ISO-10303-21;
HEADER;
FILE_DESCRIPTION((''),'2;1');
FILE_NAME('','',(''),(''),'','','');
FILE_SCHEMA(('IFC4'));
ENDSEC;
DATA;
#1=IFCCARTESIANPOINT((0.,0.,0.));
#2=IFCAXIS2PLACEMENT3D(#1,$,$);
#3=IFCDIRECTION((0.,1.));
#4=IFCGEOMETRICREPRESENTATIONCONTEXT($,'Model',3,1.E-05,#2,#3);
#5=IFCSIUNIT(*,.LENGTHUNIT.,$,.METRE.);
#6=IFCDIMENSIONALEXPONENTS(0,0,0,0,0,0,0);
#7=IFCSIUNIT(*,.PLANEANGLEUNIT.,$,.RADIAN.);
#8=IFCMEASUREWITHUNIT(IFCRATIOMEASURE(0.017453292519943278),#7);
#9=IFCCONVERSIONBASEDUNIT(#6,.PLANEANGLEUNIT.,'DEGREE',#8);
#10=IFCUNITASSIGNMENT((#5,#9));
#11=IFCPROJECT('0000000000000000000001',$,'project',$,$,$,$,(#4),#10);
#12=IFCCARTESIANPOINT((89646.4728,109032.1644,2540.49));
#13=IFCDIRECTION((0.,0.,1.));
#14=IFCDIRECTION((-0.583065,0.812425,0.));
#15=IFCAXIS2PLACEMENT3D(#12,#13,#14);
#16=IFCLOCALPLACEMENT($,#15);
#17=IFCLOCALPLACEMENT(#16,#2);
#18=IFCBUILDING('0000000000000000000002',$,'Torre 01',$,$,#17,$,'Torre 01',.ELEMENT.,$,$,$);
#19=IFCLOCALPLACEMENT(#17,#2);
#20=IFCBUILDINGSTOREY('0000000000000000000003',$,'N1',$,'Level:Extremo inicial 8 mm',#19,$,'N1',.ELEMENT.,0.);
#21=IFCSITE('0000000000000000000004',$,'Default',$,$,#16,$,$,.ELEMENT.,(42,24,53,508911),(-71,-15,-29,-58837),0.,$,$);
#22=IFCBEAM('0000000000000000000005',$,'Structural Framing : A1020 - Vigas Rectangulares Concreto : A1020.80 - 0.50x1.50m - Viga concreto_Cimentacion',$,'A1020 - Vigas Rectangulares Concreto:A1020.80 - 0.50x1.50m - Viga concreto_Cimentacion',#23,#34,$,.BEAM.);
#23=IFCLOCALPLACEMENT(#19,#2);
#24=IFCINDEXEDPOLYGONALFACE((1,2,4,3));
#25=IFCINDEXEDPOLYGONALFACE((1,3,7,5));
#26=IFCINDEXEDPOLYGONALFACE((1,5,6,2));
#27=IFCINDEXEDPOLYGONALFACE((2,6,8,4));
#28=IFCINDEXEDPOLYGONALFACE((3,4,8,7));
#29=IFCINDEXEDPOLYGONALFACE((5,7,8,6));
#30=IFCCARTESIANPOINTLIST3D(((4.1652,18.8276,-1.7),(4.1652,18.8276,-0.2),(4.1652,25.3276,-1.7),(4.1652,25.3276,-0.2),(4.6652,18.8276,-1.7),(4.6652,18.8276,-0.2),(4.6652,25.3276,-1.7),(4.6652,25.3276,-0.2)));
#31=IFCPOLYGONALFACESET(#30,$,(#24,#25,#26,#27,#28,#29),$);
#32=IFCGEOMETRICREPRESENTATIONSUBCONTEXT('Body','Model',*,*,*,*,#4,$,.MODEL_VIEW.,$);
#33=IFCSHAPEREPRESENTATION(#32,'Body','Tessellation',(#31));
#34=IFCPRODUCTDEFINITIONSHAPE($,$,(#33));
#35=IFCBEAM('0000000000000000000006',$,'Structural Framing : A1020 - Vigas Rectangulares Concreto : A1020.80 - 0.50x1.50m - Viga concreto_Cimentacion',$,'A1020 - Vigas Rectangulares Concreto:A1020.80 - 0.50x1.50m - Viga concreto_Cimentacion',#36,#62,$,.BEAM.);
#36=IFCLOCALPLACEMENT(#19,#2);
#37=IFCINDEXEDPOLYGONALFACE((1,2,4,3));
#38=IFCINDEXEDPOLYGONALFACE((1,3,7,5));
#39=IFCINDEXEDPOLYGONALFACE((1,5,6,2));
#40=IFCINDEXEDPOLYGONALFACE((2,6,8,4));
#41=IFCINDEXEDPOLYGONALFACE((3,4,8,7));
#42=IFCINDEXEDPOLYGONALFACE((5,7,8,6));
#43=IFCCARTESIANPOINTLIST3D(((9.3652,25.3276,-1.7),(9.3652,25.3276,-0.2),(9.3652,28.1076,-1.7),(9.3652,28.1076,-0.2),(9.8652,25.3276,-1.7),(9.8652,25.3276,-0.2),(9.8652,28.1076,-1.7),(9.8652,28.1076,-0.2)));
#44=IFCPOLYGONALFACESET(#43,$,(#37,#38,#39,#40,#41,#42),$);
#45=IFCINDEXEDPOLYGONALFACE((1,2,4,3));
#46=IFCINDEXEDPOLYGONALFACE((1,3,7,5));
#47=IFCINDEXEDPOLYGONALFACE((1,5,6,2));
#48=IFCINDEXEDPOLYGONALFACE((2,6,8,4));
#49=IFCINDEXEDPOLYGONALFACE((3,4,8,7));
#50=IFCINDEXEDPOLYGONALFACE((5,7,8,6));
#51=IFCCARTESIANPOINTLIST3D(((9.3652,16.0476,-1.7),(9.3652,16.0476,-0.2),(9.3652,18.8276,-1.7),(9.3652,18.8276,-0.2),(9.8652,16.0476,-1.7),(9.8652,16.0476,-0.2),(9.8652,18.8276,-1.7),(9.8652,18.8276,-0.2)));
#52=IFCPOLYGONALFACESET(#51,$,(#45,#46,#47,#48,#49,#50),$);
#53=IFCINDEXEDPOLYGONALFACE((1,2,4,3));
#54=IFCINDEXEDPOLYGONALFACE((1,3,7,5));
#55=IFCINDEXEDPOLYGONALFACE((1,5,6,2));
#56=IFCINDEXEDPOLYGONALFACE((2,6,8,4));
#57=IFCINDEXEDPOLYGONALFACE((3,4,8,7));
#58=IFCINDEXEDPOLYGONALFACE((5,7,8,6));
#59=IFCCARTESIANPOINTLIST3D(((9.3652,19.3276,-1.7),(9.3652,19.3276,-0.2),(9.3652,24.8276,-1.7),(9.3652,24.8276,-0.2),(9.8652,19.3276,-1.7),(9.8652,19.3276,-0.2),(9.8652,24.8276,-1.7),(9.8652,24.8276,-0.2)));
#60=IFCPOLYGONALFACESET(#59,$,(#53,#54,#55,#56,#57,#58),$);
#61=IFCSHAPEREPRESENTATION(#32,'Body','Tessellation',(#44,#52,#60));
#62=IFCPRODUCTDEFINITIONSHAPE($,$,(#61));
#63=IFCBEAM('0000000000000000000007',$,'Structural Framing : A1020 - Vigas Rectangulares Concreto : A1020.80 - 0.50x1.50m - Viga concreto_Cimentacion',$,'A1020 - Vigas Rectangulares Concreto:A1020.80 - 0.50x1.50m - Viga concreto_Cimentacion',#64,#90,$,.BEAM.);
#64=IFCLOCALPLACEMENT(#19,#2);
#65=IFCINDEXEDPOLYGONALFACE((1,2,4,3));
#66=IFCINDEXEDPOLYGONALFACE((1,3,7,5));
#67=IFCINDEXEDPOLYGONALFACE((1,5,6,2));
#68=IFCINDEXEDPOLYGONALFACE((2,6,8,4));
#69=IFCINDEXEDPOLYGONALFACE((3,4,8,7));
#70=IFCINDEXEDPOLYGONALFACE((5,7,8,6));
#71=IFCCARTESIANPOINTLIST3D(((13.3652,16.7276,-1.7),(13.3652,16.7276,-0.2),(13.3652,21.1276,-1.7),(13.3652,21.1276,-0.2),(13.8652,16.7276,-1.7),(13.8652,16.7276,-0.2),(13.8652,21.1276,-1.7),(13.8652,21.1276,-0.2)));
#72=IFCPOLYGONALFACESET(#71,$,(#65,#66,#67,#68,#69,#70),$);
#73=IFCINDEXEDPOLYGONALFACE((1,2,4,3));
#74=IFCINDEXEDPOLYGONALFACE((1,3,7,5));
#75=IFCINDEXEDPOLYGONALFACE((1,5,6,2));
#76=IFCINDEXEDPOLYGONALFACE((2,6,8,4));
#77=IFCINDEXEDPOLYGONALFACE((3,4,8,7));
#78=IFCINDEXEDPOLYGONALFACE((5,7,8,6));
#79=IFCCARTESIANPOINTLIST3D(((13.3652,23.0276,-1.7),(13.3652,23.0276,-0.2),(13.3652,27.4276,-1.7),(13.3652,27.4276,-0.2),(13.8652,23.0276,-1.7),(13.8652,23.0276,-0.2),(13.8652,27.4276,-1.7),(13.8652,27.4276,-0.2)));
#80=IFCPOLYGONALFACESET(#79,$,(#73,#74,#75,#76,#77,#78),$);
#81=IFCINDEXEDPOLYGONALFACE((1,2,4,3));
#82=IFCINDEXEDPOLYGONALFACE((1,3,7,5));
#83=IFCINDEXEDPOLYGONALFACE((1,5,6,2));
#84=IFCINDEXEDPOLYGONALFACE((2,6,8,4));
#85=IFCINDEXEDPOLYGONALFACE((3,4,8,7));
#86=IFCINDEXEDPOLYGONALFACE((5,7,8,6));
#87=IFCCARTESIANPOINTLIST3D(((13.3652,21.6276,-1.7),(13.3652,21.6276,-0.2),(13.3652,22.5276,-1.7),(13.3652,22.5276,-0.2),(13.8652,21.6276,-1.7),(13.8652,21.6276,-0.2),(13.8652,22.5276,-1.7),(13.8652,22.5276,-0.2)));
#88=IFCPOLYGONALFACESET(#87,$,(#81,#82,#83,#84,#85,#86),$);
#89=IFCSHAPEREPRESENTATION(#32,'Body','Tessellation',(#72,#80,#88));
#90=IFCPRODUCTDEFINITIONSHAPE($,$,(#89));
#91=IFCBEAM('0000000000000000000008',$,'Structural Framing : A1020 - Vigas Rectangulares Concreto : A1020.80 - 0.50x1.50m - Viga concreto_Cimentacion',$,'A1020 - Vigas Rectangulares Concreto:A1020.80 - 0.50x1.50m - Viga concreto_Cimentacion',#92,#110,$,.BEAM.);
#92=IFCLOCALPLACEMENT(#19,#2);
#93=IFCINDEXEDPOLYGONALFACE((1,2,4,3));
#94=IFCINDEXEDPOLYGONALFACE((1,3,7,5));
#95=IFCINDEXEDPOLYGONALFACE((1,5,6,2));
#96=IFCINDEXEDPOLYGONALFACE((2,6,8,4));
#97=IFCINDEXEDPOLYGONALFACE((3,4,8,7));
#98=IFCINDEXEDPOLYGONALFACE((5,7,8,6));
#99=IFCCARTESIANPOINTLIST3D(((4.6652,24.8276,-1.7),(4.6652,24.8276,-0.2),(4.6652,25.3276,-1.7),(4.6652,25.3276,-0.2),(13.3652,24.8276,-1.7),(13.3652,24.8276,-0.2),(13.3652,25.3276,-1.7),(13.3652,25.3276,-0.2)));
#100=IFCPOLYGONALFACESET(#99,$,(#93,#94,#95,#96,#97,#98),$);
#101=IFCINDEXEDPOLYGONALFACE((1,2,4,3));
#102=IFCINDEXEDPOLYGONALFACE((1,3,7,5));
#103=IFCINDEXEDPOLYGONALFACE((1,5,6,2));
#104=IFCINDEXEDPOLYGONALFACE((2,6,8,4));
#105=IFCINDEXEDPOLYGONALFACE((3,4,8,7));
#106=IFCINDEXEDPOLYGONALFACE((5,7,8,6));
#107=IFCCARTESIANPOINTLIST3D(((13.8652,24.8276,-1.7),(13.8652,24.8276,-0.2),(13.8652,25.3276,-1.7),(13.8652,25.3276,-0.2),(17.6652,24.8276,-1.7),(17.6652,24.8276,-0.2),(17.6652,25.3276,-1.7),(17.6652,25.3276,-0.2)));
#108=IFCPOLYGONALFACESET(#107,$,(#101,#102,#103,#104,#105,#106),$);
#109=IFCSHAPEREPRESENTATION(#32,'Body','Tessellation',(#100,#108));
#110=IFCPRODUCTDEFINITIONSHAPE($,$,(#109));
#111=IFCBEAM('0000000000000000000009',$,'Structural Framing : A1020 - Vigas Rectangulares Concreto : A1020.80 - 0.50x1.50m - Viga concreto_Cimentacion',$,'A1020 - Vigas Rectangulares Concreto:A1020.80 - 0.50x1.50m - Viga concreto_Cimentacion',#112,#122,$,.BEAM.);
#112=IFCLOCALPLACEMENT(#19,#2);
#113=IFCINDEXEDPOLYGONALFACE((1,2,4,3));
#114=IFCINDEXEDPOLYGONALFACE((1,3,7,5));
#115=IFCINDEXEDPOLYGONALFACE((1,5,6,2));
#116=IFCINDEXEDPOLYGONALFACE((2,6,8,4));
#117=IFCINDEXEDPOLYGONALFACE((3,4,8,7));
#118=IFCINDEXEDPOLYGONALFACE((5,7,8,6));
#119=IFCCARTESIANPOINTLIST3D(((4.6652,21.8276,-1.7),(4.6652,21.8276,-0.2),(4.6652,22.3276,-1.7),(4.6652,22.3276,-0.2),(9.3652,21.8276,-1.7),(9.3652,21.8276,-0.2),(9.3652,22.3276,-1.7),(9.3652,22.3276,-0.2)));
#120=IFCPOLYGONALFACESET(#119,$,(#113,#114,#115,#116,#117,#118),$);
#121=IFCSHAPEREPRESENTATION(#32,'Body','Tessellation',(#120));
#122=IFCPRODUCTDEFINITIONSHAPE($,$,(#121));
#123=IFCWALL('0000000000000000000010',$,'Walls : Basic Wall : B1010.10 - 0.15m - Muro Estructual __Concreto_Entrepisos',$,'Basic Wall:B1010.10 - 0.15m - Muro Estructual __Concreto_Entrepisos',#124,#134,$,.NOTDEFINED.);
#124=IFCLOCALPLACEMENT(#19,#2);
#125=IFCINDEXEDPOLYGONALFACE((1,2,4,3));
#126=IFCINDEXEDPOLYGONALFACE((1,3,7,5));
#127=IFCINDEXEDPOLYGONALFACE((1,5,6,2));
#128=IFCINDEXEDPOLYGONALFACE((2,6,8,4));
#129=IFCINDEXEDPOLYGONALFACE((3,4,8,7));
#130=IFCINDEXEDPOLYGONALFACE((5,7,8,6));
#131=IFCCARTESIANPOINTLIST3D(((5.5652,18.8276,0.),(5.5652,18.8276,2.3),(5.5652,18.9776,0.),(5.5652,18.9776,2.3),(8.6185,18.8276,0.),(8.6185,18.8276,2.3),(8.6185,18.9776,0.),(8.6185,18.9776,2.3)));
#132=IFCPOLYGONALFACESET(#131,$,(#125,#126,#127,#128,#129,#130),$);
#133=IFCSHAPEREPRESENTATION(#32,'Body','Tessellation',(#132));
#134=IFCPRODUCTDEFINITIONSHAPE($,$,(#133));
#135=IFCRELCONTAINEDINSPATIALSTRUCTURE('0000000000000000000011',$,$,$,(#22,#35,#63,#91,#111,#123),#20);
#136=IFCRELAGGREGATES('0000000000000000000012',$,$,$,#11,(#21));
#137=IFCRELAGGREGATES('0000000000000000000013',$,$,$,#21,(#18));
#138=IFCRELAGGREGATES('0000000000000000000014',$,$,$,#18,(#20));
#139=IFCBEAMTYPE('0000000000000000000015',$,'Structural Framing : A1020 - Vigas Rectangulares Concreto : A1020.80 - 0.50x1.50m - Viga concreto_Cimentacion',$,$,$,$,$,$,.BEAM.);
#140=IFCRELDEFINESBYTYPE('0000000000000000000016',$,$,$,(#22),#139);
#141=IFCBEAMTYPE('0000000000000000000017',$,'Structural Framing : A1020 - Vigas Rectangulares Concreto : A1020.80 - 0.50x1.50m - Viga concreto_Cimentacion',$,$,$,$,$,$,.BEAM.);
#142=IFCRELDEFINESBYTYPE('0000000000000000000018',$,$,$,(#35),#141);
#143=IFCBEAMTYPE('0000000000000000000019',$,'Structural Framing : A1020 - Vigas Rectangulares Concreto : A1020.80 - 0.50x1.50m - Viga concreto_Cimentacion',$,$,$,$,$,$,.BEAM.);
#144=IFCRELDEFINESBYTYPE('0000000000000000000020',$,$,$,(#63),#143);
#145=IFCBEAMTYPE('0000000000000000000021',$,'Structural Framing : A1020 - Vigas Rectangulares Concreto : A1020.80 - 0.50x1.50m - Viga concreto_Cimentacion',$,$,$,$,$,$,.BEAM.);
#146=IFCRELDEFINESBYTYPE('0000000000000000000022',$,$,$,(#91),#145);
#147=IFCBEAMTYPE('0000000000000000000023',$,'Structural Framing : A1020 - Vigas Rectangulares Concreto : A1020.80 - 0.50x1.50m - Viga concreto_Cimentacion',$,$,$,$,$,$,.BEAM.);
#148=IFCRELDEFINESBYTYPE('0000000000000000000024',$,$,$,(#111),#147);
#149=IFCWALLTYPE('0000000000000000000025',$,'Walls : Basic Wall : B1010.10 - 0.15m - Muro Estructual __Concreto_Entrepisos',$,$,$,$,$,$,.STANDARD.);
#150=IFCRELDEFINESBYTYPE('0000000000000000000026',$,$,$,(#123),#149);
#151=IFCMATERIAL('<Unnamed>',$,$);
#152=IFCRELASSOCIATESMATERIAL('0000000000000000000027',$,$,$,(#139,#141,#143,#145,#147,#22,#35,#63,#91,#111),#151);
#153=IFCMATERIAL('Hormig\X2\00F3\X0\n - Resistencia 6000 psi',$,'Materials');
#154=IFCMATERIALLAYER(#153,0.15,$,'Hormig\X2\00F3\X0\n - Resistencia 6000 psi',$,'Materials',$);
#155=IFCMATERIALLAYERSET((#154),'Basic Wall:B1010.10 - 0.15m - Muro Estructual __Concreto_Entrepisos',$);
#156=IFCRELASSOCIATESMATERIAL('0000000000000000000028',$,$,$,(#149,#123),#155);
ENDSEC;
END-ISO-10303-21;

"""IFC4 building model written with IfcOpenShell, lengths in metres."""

from ifc_helpers import new_model, entity, si_unit, converted_unit, direction, frame, frame_2d, origin, place, context, subcontext, project, spatial, polyline, segment, composite_curve, rectangle, outline, extrude, source, transform, mapped, material, layer, layer_set, layer_usage, material_profile, profile_set, profile_usage, type_object, type_shapes, element, save


model = new_model("IFC4")

# Units and contexts
model_context = context("Model", 3, precision=1e-05, world=origin(), true_north=direction((0.0, 1.0)))
body_context = subcontext(model_context, "Body", "Model", "MODEL_VIEW")
ifc_project = project(units=[si_unit("LENGTHUNIT", "METRE"), converted_unit("PLANEANGLEUNIT", "DEGREE", entity("IfcRatioMeasure", 0.017453292519943278), si_unit("PLANEANGLEUNIT", "RADIAN"), dimensions=[0, 0, 0, 0, 0, 0, 0])], contexts=[model_context])

# Site, building, storey
site_placement = place(None, frame((89646.4728, 109032.1644, 2540.49), z_axis=(0.0, 0.0, 1.0), x_axis=(-0.583065, 0.812425, 0.0)))
site = spatial("IfcSite", under=ifc_project, at=site_placement, Name="Default", CompositionType="ELEMENT", RefLatitude=(42, 24, 53, 508911), RefLongitude=(-71, -15, -29, -58837), RefElevation=0.0)
building_placement = place(site_placement, origin())
building = spatial("IfcBuilding", under=site, at=building_placement, Name="Torre 01", LongName="Torre 01", CompositionType="ELEMENT")
storey_placement = place(building_placement, origin())
storey = spatial("IfcBuildingStorey", under=building, at=storey_placement, Name="N1", ObjectType="Level:Extremo inicial 8 mm", LongName="N1", CompositionType="ELEMENT", Elevation=0.0)

# Beams
ifc_material_1 = material(Name="<Unnamed>")
ifc_material_profile_1 = material_profile(ifc_material_1, outline(composite_curve([segment(polyline([(-0.25, -0.75, 0.0), (-0.25, 0.75, 0.0)]), True, "CONTINUOUS"), segment(polyline([(-0.25, 0.75, 0.0), (0.25, 0.75, 0.0)]), True, "CONTINUOUS"), segment(polyline([(0.25, 0.75, 0.0), (0.25, -0.75, 0.0)]), True, "CONTINUOUS"), segment(polyline([(0.25, -0.75, 0.0), (-0.25, -0.75, 0.0)]), True, "CONTINUOUS")], self_intersect=False), kind="CURVE"), Name="A1020.80 - 0.50x1.50m - Viga concreto_Cimentacion")
ifc_material_profile_2 = material_profile(ifc_material_1, outline(composite_curve([segment(polyline([(2.7373, 0.25, 0.75), (2.7373, 0.25, -0.75)]), True, "CONTINUOUS"), segment(polyline([(2.7373, 0.25, -0.75), (-2.7373, 0.25, -0.75)]), True, "CONTINUOUS"), segment(polyline([(-2.7373, 0.25, -0.75), (-2.7373, 0.25, 0.75)]), True, "CONTINUOUS"), segment(polyline([(-2.7373, 0.25, 0.75), (2.7373, 0.25, 0.75)]), True, "CONTINUOUS")], self_intersect=False), kind="CURVE"), Name="A1020.80 - 0.50x1.50m - Viga concreto_Cimentacion")
ifc_profile_set_1 = profile_set([ifc_material_profile_1, ifc_material_profile_2], Name="A1020.80 - 0.50x1.50m - Viga concreto_Cimentacion")
ifc_profile_usage_1 = profile_usage(ifc_profile_set_1, cardinal=8)
beam_type_1 = type_object("IfcBeamType", Name="Structural Framing : A1020 - Vigas Rectangulares Concreto : A1020.80 - 0.50x1.50m - Viga concreto_Cimentacion", PredefinedType="BEAM", material=ifc_profile_set_1)
shared_shape_1 = source(origin(), body_context, "Body", "SweptSolid", [
    extrude(rectangle(XDim=1.5, YDim=0.5, at=frame_2d((0.0, 0.0), x_axis=(0.0, 1.0))), frame((4.4152, 18.8276, -0.95), z_axis=(0.0, 1.0, 0.0), x_axis=(-1.0, 0.0, 0.0)), (0.0, 0.0, 1.0), 6.5),
])
type_shapes(beam_type_1, [shared_shape_1])
beam_1_placement = place(storey_placement, origin())
element("IfcBeam", 1, at=beam_1_placement, inside=storey, type_object=beam_type_1, material=ifc_profile_usage_1, Name="Structural Framing : A1020 - Vigas Rectangulares Concreto : A1020.80 - 0.50x1.50m - Viga concreto_Cimentacion", ObjectType="A1020 - Vigas Rectangulares Concreto:A1020.80 - 0.50x1.50m - Viga concreto_Cimentacion", PredefinedType="BEAM", context=body_context, shape_type="MappedRepresentation", body=[
    mapped(shared_shape_1, transform((0.0, 0.0, 0.0), scale=1.0)),
])
ifc_profile_usage_2 = profile_usage(ifc_profile_set_1, cardinal=8)
beam_type_2 = type_object("IfcBeamType", Name="Structural Framing : A1020 - Vigas Rectangulares Concreto : A1020.80 - 0.50x1.50m - Viga concreto_Cimentacion", PredefinedType="BEAM", material=ifc_profile_set_1)
shared_shape_2 = source(origin(), body_context, "Body", "SweptSolid", [
    extrude(rectangle(XDim=1.5, YDim=0.5, at=frame_2d((0.0, 0.0), x_axis=(0.0, 1.0))), frame((9.6152, 25.3276, -0.95), z_axis=(0.0, 1.0, 0.0), x_axis=(-1.0, 0.0, 0.0)), (0.0, 0.0, 1.0), 2.78),
    extrude(rectangle(XDim=1.5, YDim=0.5, at=frame_2d((0.0, 0.0), x_axis=(0.0, 1.0))), frame((9.6152, 16.0476, -0.95), z_axis=(0.0, 1.0, 0.0), x_axis=(-1.0, 0.0, 0.0)), (0.0, 0.0, 1.0), 2.78),
    extrude(rectangle(XDim=1.5, YDim=0.5, at=frame_2d((0.0, 0.0), x_axis=(0.0, 1.0))), frame((9.6152, 19.3276, -0.95), z_axis=(0.0, 1.0, 0.0), x_axis=(-1.0, 0.0, 0.0)), (0.0, 0.0, 1.0), 5.5),
])
type_shapes(beam_type_2, [shared_shape_2])
beam_2_placement = place(storey_placement, origin())
element("IfcBeam", 2, at=beam_2_placement, inside=storey, type_object=beam_type_2, material=ifc_profile_usage_2, Name="Structural Framing : A1020 - Vigas Rectangulares Concreto : A1020.80 - 0.50x1.50m - Viga concreto_Cimentacion", ObjectType="A1020 - Vigas Rectangulares Concreto:A1020.80 - 0.50x1.50m - Viga concreto_Cimentacion", PredefinedType="BEAM", context=body_context, shape_type="MappedRepresentation", body=[
    mapped(shared_shape_2, transform((0.0, 0.0, 0.0), scale=1.0)),
])
ifc_profile_usage_3 = profile_usage(ifc_profile_set_1, cardinal=8)
beam_type_3 = type_object("IfcBeamType", Name="Structural Framing : A1020 - Vigas Rectangulares Concreto : A1020.80 - 0.50x1.50m - Viga concreto_Cimentacion", PredefinedType="BEAM", material=ifc_profile_set_1)
shared_shape_3 = source(origin(), body_context, "Body", "SweptSolid", [
    extrude(rectangle(XDim=1.5, YDim=0.5, at=frame_2d((0.0, 0.0), x_axis=(0.0, 1.0))), frame((13.6152, 16.7276, -0.95), z_axis=(0.0, 1.0, 0.0), x_axis=(-1.0, 0.0, 0.0)), (0.0, 0.0, 1.0), 4.4),
    extrude(rectangle(XDim=1.5, YDim=0.5, at=frame_2d((0.0, 0.0), x_axis=(0.0, 1.0))), frame((13.6152, 23.0276, -0.95), z_axis=(0.0, 1.0, 0.0), x_axis=(-1.0, 0.0, 0.0)), (0.0, 0.0, 1.0), 4.4),
    extrude(rectangle(XDim=1.5, YDim=0.5, at=frame_2d((0.0, 0.0), x_axis=(0.0, 1.0))), frame((13.6152, 21.6276, -0.95), z_axis=(0.0, 1.0, 0.0), x_axis=(-1.0, 0.0, 0.0)), (0.0, 0.0, 1.0), 0.9),
])
type_shapes(beam_type_3, [shared_shape_3])
beam_3_placement = place(storey_placement, origin())
element("IfcBeam", 3, at=beam_3_placement, inside=storey, type_object=beam_type_3, material=ifc_profile_usage_3, Name="Structural Framing : A1020 - Vigas Rectangulares Concreto : A1020.80 - 0.50x1.50m - Viga concreto_Cimentacion", ObjectType="A1020 - Vigas Rectangulares Concreto:A1020.80 - 0.50x1.50m - Viga concreto_Cimentacion", PredefinedType="BEAM", context=body_context, shape_type="MappedRepresentation", body=[
    mapped(shared_shape_3, transform((0.0, 0.0, 0.0), scale=1.0)),
])
ifc_profile_usage_4 = profile_usage(ifc_profile_set_1, cardinal=8)
beam_type_4 = type_object("IfcBeamType", Name="Structural Framing : A1020 - Vigas Rectangulares Concreto : A1020.80 - 0.50x1.50m - Viga concreto_Cimentacion", PredefinedType="BEAM", material=ifc_profile_set_1)
shared_shape_4 = source(origin(), body_context, "Body", "SweptSolid", [
    extrude(rectangle(XDim=1.5, YDim=0.5, at=frame_2d((0.0, 0.0), x_axis=(1.0, 0.0))), frame((4.6652, 25.0776, -0.95), z_axis=(1.0, 0.0, 0.0), x_axis=(0.0, 0.0, -1.0)), (0.0, 0.0, 1.0), 8.7),
    extrude(rectangle(XDim=1.5, YDim=0.5, at=frame_2d((0.0, 0.0), x_axis=(1.0, 0.0))), frame((13.8652, 25.0776, -0.95), z_axis=(1.0, 0.0, 0.0), x_axis=(0.0, 0.0, -1.0)), (0.0, 0.0, 1.0), 3.8),
])
type_shapes(beam_type_4, [shared_shape_4])
beam_4_placement = place(storey_placement, origin())
element("IfcBeam", 4, at=beam_4_placement, inside=storey, type_object=beam_type_4, material=ifc_profile_usage_4, Name="Structural Framing : A1020 - Vigas Rectangulares Concreto : A1020.80 - 0.50x1.50m - Viga concreto_Cimentacion", ObjectType="A1020 - Vigas Rectangulares Concreto:A1020.80 - 0.50x1.50m - Viga concreto_Cimentacion", PredefinedType="BEAM", context=body_context, shape_type="MappedRepresentation", body=[
    mapped(shared_shape_4, transform((0.0, 0.0, 0.0), scale=1.0)),
])
ifc_profile_usage_5 = profile_usage(ifc_profile_set_1, cardinal=8)
beam_type_5 = type_object("IfcBeamType", Name="Structural Framing : A1020 - Vigas Rectangulares Concreto : A1020.80 - 0.50x1.50m - Viga concreto_Cimentacion", PredefinedType="BEAM", material=ifc_profile_set_1)
shared_shape_5 = source(origin(), body_context, "Body", "SweptSolid", [
    extrude(rectangle(XDim=1.5, YDim=0.5, at=frame_2d((0.0, 0.0), x_axis=(1.0, 0.0))), frame((4.6652, 22.0776, -0.95), z_axis=(1.0, 0.0, 0.0), x_axis=(0.0, 0.0, -1.0)), (0.0, 0.0, 1.0), 4.7),
])
type_shapes(beam_type_5, [shared_shape_5])
beam_5_placement = place(storey_placement, origin())
element("IfcBeam", 5, at=beam_5_placement, inside=storey, type_object=beam_type_5, material=ifc_profile_usage_5, Name="Structural Framing : A1020 - Vigas Rectangulares Concreto : A1020.80 - 0.50x1.50m - Viga concreto_Cimentacion", ObjectType="A1020 - Vigas Rectangulares Concreto:A1020.80 - 0.50x1.50m - Viga concreto_Cimentacion", PredefinedType="BEAM", context=body_context, shape_type="MappedRepresentation", body=[
    mapped(shared_shape_5, transform((0.0, 0.0, 0.0), scale=1.0)),
])

# Wall
ifc_material_2 = material(Name="Hormigón - Resistencia 6000 psi", Category="Materials")
ifc_layer_1 = layer(ifc_material_2, 0.15, Name="Hormigón - Resistencia 6000 psi", Category="Materials")
ifc_layer_set_1 = layer_set([ifc_layer_1], Name="Basic Wall:B1010.10 - 0.15m - Muro Estructual __Concreto_Entrepisos")
ifc_layer_usage_1 = layer_usage(ifc_layer_set_1, "AXIS2", "POSITIVE", -0.075)
wall_type = type_object("IfcWallType", Name="Walls : Basic Wall : B1010.10 - 0.15m - Muro Estructual __Concreto_Entrepisos", PredefinedType="STANDARD", material=ifc_layer_set_1)
wall_placement = place(storey_placement, frame((5.5652, 18.9026, 0.0)))
element("IfcWall", 6, at=wall_placement, inside=storey, type_object=wall_type, material=ifc_layer_usage_1, Name="Walls : Basic Wall : B1010.10 - 0.15m - Muro Estructual __Concreto_Entrepisos", ObjectType="Basic Wall:B1010.10 - 0.15m - Muro Estructual __Concreto_Entrepisos", PredefinedType="NOTDEFINED", context=body_context, shape_type="SweptSolid", body=[
    extrude(rectangle(XDim=3.0533, YDim=0.15, at=frame_2d((1.5267, 0.0), x_axis=(-1.0, 0.0))), origin(), (0.0, 0.0, 1.0), 2.3),
])

save(model, "model.ifc")
